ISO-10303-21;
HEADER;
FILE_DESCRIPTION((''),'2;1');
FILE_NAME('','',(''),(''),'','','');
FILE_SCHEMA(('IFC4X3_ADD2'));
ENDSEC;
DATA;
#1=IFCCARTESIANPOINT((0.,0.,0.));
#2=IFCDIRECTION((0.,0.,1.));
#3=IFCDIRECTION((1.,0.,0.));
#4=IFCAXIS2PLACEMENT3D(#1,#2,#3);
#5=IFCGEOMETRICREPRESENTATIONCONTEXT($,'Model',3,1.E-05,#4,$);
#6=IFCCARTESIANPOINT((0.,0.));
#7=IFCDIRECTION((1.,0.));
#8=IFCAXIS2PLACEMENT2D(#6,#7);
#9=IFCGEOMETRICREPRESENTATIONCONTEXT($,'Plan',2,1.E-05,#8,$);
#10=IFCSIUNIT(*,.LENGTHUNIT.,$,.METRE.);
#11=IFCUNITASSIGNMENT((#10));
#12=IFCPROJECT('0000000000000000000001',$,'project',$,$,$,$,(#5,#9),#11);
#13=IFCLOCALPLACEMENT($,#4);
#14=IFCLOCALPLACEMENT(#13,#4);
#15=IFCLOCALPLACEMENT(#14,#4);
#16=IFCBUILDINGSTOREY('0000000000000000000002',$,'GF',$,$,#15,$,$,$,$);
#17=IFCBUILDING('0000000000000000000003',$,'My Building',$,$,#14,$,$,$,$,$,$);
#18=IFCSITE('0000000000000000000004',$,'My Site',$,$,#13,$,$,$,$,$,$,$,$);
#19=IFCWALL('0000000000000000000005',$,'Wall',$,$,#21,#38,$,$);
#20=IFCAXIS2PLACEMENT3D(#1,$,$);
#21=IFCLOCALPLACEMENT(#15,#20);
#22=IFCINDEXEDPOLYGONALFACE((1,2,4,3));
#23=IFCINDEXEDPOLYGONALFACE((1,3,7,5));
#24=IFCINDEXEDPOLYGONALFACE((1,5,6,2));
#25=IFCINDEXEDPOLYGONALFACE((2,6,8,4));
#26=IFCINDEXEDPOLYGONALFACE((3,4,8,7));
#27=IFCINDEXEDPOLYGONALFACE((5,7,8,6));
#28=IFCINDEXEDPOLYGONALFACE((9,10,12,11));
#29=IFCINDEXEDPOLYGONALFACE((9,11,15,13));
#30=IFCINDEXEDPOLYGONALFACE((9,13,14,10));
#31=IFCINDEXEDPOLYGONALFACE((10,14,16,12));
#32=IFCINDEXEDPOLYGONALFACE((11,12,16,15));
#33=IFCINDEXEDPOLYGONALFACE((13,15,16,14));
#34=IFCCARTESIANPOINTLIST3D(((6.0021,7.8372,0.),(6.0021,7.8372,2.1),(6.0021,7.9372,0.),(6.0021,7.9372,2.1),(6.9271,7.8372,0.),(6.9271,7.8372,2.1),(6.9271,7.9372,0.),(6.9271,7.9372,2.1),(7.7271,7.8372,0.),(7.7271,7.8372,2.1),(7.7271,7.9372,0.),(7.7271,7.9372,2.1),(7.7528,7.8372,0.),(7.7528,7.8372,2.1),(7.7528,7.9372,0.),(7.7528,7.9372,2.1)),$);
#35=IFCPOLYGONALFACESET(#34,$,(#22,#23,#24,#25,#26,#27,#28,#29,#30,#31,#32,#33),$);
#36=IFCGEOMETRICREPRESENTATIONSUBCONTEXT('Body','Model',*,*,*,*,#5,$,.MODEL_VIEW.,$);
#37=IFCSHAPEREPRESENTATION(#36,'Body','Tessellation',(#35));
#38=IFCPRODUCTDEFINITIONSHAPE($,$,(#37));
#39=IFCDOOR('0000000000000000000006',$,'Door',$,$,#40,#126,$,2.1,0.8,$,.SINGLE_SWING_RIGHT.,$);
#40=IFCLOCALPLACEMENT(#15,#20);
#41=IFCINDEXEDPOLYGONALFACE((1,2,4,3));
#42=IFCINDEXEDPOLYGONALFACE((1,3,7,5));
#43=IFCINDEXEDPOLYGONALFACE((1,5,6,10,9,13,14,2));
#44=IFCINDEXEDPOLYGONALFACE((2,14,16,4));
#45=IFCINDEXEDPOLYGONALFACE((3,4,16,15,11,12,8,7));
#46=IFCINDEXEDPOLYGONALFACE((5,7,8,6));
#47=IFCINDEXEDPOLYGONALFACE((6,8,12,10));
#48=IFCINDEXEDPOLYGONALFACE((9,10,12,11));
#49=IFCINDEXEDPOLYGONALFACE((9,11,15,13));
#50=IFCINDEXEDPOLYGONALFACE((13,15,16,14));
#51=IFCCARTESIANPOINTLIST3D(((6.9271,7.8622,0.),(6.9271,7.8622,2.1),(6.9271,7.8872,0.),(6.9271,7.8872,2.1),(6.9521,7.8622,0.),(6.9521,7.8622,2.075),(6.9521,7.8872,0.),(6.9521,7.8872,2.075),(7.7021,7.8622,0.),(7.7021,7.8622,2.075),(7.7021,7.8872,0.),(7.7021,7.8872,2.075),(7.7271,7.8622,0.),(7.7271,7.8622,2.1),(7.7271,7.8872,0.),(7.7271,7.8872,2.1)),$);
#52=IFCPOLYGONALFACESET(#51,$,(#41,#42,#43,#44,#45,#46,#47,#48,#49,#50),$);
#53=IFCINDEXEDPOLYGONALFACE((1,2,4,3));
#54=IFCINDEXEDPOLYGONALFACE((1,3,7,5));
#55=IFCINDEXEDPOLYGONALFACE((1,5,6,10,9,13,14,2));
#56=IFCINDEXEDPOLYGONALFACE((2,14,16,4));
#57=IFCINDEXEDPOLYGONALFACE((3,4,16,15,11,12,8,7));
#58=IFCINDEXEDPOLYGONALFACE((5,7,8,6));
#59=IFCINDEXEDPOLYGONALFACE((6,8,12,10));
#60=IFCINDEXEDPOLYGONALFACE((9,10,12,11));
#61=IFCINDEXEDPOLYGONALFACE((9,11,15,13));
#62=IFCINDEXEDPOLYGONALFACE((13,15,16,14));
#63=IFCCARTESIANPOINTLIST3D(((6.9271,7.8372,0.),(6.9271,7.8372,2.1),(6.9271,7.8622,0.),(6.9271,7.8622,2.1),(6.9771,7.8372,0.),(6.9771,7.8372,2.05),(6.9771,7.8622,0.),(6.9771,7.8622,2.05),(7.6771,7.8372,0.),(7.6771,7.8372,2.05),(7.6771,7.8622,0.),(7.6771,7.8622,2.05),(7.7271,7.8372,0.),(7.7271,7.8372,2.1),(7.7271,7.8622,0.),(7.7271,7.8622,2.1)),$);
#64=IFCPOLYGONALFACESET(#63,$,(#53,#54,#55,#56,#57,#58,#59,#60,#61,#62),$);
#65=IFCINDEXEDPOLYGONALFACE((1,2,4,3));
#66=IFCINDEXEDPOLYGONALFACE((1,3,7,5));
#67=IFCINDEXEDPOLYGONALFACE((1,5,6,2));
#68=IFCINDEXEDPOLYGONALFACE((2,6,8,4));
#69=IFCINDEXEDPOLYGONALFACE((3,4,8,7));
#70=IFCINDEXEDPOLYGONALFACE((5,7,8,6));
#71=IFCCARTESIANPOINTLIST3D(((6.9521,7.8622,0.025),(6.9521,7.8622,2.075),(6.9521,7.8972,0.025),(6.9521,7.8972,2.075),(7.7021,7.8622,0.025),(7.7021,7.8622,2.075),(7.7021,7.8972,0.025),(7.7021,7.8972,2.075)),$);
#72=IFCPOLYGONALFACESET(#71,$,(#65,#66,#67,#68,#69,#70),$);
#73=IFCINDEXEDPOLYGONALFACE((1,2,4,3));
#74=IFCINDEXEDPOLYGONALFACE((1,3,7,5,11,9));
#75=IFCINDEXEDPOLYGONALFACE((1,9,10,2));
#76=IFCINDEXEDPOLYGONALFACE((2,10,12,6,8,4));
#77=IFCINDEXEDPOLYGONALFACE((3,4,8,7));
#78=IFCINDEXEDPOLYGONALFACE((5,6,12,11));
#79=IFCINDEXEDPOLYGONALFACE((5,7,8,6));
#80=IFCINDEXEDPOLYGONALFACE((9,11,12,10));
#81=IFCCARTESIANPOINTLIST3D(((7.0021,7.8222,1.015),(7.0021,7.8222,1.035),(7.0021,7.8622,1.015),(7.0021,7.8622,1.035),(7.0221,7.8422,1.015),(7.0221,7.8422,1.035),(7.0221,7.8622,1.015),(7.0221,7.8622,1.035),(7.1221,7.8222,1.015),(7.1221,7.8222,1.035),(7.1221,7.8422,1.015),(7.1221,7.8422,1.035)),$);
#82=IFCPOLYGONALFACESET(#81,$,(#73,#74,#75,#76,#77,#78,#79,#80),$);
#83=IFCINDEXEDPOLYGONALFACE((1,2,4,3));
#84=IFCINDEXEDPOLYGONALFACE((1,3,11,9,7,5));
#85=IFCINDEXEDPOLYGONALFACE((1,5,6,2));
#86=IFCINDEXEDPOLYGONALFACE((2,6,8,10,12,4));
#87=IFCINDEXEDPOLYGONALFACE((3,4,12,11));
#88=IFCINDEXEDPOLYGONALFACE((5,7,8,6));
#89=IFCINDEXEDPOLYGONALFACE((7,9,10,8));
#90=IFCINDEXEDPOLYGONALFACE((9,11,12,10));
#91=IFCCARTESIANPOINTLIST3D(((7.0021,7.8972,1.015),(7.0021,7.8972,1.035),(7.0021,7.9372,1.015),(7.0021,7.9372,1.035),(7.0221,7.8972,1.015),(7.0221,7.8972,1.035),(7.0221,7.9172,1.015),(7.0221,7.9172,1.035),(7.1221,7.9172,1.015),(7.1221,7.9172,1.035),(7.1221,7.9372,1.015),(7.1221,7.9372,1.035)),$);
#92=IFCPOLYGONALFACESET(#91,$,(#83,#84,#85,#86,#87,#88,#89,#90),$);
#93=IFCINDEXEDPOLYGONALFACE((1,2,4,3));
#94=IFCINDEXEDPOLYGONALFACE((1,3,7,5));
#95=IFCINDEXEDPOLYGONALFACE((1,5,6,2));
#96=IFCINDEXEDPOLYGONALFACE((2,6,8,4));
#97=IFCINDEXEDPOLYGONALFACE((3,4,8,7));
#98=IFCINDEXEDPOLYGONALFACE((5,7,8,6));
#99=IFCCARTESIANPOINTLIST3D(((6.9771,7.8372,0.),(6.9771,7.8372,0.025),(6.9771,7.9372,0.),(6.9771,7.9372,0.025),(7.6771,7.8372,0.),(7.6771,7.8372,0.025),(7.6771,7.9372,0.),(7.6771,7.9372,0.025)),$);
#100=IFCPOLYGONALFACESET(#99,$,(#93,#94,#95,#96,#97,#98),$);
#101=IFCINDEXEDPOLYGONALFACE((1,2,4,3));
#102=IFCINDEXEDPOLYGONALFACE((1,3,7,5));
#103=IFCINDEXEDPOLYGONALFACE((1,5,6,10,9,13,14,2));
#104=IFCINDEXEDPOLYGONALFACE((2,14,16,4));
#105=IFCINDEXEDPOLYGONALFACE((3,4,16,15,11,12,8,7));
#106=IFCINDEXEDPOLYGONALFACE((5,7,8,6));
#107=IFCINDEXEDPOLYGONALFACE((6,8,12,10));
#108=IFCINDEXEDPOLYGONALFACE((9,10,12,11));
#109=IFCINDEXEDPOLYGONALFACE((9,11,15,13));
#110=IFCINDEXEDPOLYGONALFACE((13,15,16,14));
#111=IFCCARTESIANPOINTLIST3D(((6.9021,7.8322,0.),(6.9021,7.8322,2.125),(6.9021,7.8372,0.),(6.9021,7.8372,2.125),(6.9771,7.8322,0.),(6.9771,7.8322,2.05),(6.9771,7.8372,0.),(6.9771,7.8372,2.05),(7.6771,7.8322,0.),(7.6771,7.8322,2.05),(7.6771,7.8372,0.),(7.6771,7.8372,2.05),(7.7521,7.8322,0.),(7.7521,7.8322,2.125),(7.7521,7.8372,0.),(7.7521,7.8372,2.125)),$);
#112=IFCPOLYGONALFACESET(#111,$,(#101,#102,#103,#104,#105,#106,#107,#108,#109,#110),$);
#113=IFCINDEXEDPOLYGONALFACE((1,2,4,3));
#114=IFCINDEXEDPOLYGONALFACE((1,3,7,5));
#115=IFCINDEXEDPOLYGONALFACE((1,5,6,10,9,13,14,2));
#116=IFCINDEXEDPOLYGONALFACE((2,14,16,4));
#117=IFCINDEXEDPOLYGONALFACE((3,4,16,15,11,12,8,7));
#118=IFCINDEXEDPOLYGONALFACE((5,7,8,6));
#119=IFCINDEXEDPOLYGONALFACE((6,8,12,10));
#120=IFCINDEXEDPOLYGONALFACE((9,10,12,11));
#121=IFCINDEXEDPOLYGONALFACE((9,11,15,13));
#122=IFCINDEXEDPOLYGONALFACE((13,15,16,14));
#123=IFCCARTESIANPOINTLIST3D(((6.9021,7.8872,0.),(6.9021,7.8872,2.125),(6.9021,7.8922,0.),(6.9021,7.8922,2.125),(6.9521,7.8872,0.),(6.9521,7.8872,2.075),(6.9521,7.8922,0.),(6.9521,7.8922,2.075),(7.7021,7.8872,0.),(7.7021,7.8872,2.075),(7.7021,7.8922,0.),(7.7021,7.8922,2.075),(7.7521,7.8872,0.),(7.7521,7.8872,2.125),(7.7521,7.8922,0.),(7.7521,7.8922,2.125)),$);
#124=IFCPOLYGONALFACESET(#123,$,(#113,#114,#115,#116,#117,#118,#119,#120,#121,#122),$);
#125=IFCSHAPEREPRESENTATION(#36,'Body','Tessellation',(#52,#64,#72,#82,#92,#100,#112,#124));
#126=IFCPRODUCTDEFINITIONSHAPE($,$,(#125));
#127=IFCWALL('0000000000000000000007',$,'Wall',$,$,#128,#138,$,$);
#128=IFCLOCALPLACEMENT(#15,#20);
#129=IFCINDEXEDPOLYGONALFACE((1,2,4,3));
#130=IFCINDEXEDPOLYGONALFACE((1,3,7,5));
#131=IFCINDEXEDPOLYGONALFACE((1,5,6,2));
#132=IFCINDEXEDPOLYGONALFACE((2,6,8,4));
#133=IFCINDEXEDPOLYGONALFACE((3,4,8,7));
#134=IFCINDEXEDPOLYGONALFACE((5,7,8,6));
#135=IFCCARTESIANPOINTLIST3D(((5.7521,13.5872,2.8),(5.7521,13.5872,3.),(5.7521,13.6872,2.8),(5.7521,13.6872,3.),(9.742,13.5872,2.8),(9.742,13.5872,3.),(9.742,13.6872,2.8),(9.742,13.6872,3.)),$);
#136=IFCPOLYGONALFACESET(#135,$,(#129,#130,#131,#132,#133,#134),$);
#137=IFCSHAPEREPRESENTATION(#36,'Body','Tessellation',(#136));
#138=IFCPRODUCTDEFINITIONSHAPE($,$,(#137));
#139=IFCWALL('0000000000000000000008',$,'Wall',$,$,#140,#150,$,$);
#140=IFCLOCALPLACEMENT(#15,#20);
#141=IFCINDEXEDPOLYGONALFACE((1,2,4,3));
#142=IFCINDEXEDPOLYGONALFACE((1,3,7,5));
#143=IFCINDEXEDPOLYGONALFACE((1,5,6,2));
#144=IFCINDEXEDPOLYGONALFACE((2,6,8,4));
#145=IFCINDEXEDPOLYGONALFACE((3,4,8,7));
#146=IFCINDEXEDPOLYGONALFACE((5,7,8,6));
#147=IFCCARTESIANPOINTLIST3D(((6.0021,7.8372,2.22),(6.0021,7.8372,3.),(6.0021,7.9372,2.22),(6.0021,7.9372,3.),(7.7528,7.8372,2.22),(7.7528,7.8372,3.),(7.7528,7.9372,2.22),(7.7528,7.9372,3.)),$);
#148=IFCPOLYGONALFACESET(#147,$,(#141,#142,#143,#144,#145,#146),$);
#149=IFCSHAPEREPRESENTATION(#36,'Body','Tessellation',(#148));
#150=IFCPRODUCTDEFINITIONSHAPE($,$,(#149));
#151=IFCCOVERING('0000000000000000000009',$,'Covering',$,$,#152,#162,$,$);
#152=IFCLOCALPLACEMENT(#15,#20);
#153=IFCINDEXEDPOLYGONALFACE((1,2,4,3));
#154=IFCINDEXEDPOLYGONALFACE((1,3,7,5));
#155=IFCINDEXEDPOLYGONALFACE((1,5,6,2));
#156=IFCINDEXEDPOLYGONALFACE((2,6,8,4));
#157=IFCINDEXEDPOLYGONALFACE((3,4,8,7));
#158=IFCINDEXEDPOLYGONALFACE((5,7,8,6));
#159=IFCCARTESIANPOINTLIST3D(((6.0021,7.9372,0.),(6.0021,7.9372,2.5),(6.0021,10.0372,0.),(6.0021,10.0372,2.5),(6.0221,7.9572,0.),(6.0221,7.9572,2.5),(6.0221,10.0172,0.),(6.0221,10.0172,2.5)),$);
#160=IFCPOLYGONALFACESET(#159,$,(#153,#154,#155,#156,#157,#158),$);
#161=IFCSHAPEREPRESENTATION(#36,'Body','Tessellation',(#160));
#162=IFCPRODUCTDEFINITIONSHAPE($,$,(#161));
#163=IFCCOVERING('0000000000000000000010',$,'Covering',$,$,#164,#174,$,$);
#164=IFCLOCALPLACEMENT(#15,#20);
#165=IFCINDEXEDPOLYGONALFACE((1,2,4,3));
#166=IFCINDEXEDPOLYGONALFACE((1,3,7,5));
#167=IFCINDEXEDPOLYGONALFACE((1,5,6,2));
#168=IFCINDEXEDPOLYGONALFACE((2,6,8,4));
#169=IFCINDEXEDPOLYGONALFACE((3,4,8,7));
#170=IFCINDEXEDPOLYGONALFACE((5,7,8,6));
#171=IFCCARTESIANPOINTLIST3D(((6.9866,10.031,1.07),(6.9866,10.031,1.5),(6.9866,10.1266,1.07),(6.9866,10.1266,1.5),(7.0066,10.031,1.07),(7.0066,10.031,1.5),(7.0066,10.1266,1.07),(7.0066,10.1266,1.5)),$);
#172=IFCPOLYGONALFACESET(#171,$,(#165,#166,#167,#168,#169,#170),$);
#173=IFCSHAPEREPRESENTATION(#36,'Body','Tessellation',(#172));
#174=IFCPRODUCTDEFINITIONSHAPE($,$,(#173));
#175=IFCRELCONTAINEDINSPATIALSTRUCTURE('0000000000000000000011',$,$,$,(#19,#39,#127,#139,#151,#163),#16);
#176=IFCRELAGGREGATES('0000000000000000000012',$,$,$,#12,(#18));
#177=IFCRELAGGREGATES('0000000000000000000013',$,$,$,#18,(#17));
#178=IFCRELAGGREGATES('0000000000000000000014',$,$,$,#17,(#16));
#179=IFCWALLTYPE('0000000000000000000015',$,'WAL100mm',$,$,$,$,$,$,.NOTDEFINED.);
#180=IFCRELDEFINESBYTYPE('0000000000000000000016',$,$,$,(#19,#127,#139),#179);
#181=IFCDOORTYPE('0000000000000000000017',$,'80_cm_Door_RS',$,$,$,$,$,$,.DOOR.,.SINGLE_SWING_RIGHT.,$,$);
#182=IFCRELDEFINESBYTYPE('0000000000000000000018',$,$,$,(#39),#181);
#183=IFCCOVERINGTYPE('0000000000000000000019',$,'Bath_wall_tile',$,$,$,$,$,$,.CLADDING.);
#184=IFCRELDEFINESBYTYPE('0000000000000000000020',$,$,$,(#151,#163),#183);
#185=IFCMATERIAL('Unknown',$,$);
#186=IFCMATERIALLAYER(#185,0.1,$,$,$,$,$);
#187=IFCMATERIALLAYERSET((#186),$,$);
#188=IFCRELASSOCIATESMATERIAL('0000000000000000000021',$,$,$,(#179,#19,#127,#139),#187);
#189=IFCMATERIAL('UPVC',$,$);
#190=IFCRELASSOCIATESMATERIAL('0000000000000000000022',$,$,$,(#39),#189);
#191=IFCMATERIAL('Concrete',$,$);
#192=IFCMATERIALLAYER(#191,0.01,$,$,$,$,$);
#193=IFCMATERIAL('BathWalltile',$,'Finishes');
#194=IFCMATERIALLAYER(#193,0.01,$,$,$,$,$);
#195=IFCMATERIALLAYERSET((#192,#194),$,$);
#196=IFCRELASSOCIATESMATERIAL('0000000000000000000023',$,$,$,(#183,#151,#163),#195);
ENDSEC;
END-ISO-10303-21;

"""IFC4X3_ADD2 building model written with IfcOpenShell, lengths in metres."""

from ifc_helpers import new_model, entity, si_unit, frame, origin_with_axes, origin_2d_with_axis, place, context, subcontext, project, spatial, line, indexed_curve, outline, extrude, shape, source, transform, mapped, material, layer, layer_set, layer_usage, type_object, type_shapes, element, fill, save


model = new_model("IFC4X3_ADD2")

# Units and contexts
model_context = context("Model", 3, precision=1e-05, world=origin_with_axes())
plan_context = context("Plan", 2, precision=1e-05, world=origin_2d_with_axis())
body_context_1 = subcontext(model_context, "Body", "Model", "MODEL_VIEW")
body_context_2 = subcontext(plan_context, "Body", "Plan", "PLAN_VIEW")
ifc_project = project(units=[si_unit("LENGTHUNIT", "METRE")], contexts=[model_context, plan_context])

# Site, building, storey
site_placement = place(None, origin_with_axes())
site = spatial("IfcSite", under=ifc_project, at=site_placement, Name="My Site")
building_placement = place(site_placement, origin_with_axes())
building = spatial("IfcBuilding", under=site, at=building_placement, Name="My Building")
storey_placement = place(building_placement, origin_with_axes())
storey = spatial("IfcBuildingStorey", under=building, at=storey_placement, Name="GF")

# Shared definitions
ifc_material_1 = material(Name="UPVC")

# Shared definitions
ifc_material_2 = material(Name="Unknown")
ifc_layer_1 = layer(ifc_material_2, 0.1)
ifc_layer_set_1 = layer_set([ifc_layer_1])
wall_type_1 = type_object("IfcWallType", Name="WAL100mm", PredefinedType="NOTDEFINED", material=ifc_layer_set_1)

# Wall, opening, door
ifc_layer_usage_1 = layer_usage(ifc_layer_set_1, "AXIS2", "POSITIVE", 0.0)
wall_1_placement = place(storey_placement, frame((6.0021, 7.8372, 0.0), z_axis=(0.0, 0.0, 1.0), x_axis=(1.0, 0.0, 0.0)))
wall_1 = element("IfcWall", 1, at=wall_1_placement, inside=storey, type_object=wall_type_1, material=ifc_layer_usage_1, Name="Wall", context=body_context_1, shape_type="SweptSolid", body=[
    extrude(outline(indexed_curve([(0.0, 0.0), (0.0, 0.1), (1.7507, 0.1), (1.7507, 0.0)], segments=[line(1, 2, 3, 4, 1)])), origin_with_axes(), (0.0, 0.0, 1.0), 2.1),
])
shared_shape_1 = source(origin_with_axes(), body_context_1, "Body", "SweptSolid", [
    extrude(outline(indexed_curve([(0.0, 0.0), (0.8, 0.0), (0.8, 2.1), (0.0, 2.1)], segments=[line(1, 2, 3, 4, 1)])), frame((0.0, -0.6, 0.0), z_axis=(0.0, -1.0, 0.0), x_axis=(1.0, 0.0, 0.0)), (0.0, 0.0, -1.0), 1.2),
])
opening_1_placement = place(wall_1_placement, frame((0.925, 0.0, 0.0), z_axis=(0.0, 0.0, 1.0), x_axis=(1.0, -0.000003, 0.0)))
opening_1 = element("IfcOpeningElement", 2, at=opening_1_placement, cuts=wall_1, PredefinedType="OPENING", context=body_context_1, shape_type="MappedRepresentation", body=[
    mapped(shared_shape_1, transform((0.0, 0.0, 0.0), x_axis=(1.0, 0.0, 0.0), y_axis=(0.0, 1.0, 0.0), z_axis=(0.0, 0.0, 1.0), scale=1.0)),
])
door_type_1 = type_object("IfcDoorType", Name="80_cm_Door_RS", OperationType="SINGLE_SWING_RIGHT", PredefinedType="DOOR")
shared_shape_2 = source(origin_with_axes(), body_context_1, "Body", "SweptSolid", [
    extrude(outline(indexed_curve([(0.0, 0.0), (0.0, 2.1), (0.8, 2.1), (0.8, 0.0), (0.775, 0.0), (0.775, 2.075), (0.025, 2.075), (0.025, 0.0)], segments=[line(1, 2, 3, 4, 5, 6, 7, 8, 1)])), frame((0.0, 0.025, 0.0), z_axis=(0.0, -1.0, 0.0), x_axis=(1.0, 0.0, 0.0)), (0.0, 0.0, -1.0), 0.025),
    extrude(outline(indexed_curve([(0.0, 0.0), (0.0, 2.1), (0.8, 2.1), (0.8, 0.0), (0.75, 0.0), (0.75, 2.05), (0.05, 2.05), (0.05, 0.0)], segments=[line(1, 2, 3, 4, 5, 6, 7, 8, 1)])), frame((0.0, 0.0, 0.0), z_axis=(0.0, -1.0, 0.0), x_axis=(1.0, 0.0, 0.0)), (0.0, 0.0, -1.0), 0.025),
    extrude(outline(indexed_curve([(0.0, 0.0), (0.75, 0.0), (0.75, 0.035), (0.0, 0.035)], segments=[line(1, 2, 3, 4, 1)])), frame((0.025, 0.025, 0.025), z_axis=(0.0, 0.0, 1.0), x_axis=(1.0, 0.0, 0.0)), (0.0, 0.0, 1.0), 2.05),
    extrude(outline(indexed_curve([(0.0, 0.0), (0.0, -0.04), (0.12, -0.04), (0.12, -0.02), (0.02, -0.02), (0.02, 0.0)], segments=[line(1, 2, 3, 4, 5, 6, 1)])), frame((0.075, 0.025, 1.015), z_axis=(0.0, 0.0, 1.0), x_axis=(1.0, 0.0, 0.0)), (0.0, 0.0, 1.0), 0.02),
    extrude(outline(indexed_curve([(0.0, 0.0), (0.0, 0.04), (0.12, 0.04), (0.12, 0.02), (0.02, 0.02), (0.02, 0.0)], segments=[line(1, 2, 3, 4, 5, 6, 1)])), frame((0.075, 0.06, 1.015), z_axis=(0.0, 0.0, 1.0), x_axis=(1.0, 0.0, 0.0)), (0.0, 0.0, 1.0), 0.02),
    extrude(outline(indexed_curve([(0.0, 0.0), (0.7, 0.0), (0.7, 0.1), (0.0, 0.1)], segments=[line(1, 2, 3, 4, 1)])), frame((0.05, 0.0, 0.0), z_axis=(0.0, 0.0, 1.0), x_axis=(1.0, 0.0, 0.0)), (0.0, 0.0, 1.0), 0.025),
    extrude(outline(indexed_curve([(0.0, 0.0), (0.0, 2.125), (0.85, 2.125), (0.85, 0.0), (0.775, 0.0), (0.775, 2.05), (0.075, 2.05), (0.075, 0.0)], segments=[line(1, 2, 3, 4, 5, 6, 7, 8, 1)])), frame((-0.025, -0.005, 0.0), z_axis=(0.0, -1.0, 0.0), x_axis=(1.0, 0.0, 0.0)), (0.0, 0.0, -1.0), 0.005),
    extrude(outline(indexed_curve([(0.0, 0.0), (0.0, 2.125), (0.85, 2.125), (0.85, 0.0), (0.8, 0.0), (0.8, 2.075), (0.05, 2.075), (0.05, 0.0)], segments=[line(1, 2, 3, 4, 5, 6, 7, 8, 1)])), frame((-0.025, 0.05, 0.0), z_axis=(0.0, -1.0, 0.0), x_axis=(1.0, 0.0, 0.0)), (0.0, 0.0, -1.0), 0.005),
])
shared_shape_3 = source(origin_with_axes(), body_context_2, "Body", "Curve2D", [
    entity("IfcIndexedPolyCurve", entity("IfcCartesianPointList2D", [[0.0, 0.0], [0.0, 0.05], [0.025, 0.05], [0.025, 0.025], [0.05, 0.025], [0.05, 0.0]]), [entity("IfcLineIndex", [1, 2, 3, 4, 5, 6, 1])]),
    entity("IfcIndexedPolyCurve", entity("IfcCartesianPointList2D", [[0.8, 0.0], [0.8, 0.05], [0.775, 0.05], [0.775, 0.025], [0.75, 0.025], [0.75, 0.0]]), [entity("IfcLineIndex", [1, 2, 3, 4, 5, 6, 1])]),
    entity("IfcTrimmedCurve", entity("IfcEllipse", entity("IfcAxis2Placement2D", entity("IfcCartesianPoint", [0.74, 0.05]), entity("IfcDirection", [1.0, 0.0])), 0.715, 0.75), [entity("IfcCartesianPoint", [0.74, 0.8])], [entity("IfcCartesianPoint", [0.025, 0.05])], True, "CARTESIAN"),
    entity("IfcIndexedPolyCurve", entity("IfcCartesianPointList2D", [[0.775, 0.05], [0.74, 0.05], [0.74, 0.8], [0.775, 0.8]]), [entity("IfcLineIndex", [1, 2, 3, 4, 1])]),
])
type_shapes(door_type_1, [shared_shape_2, shared_shape_3])
door_1_placement = place(opening_1_placement, frame((0.0, 0.0, 0.0), z_axis=(0.0, 0.0, 1.0), x_axis=(1.0, 0.0, 0.0)))
door_1 = element("IfcDoor", 3, at=door_1_placement, inside=storey, type_object=door_type_1, material=ifc_material_1, Name="Door", OperationType="SINGLE_SWING_RIGHT", OverallHeight=2.1, OverallWidth=0.8, shapes=[
    shape(body_context_1, "Body", "MappedRepresentation", [mapped(shared_shape_2, transform((0.0, 0.0, 0.0), x_axis=(1.0, 0.0, 0.0), y_axis=(0.0, 1.0, 0.0), z_axis=(0.0, 0.0, 1.0), scale=1.0))]),
    shape(body_context_2, "Body", "MappedRepresentation", [mapped(shared_shape_3, transform((0.0, 0.0, 0.0), x_axis=(1.0, 0.0, 0.0), y_axis=(0.0, 1.0, 0.0), z_axis=(0.0, 0.0, 1.0), scale=1.0))]),
])
fill(opening_1, door_1)

# Walls
ifc_layer_usage_2 = layer_usage(ifc_layer_set_1, "AXIS2", "POSITIVE", 0.0)
wall_2_placement = place(storey_placement, frame((5.7521, 13.5872, 2.8), z_axis=(0.0, 0.0, 1.0), x_axis=(1.0, 0.0, 0.0)))
element("IfcWall", 4, at=wall_2_placement, inside=storey, type_object=wall_type_1, material=ifc_layer_usage_2, Name="Wall", context=body_context_1, shape_type="SweptSolid", body=[
    extrude(outline(indexed_curve([(0.0, 0.0), (0.0, 0.1), (3.9899, 0.1), (3.9899, 0.0)], segments=[line(1, 2, 3, 4, 1)])), origin_with_axes(), (0.0, 0.0, 1.0), 0.2),
])
ifc_layer_usage_3 = layer_usage(ifc_layer_set_1, "AXIS2", "POSITIVE", 0.0)
wall_3_placement = place(storey_placement, frame((6.0021, 7.8372, 2.22), z_axis=(0.0, 0.0, 1.0), x_axis=(1.0, 0.0, 0.0)))
element("IfcWall", 5, at=wall_3_placement, inside=storey, type_object=wall_type_1, material=ifc_layer_usage_3, Name="Wall", context=body_context_1, shape_type="SweptSolid", body=[
    extrude(outline(indexed_curve([(0.0, 0.0), (0.0, 0.1), (1.7507, 0.1), (1.7507, 0.0)], segments=[line(1, 2, 3, 4, 1)])), origin_with_axes(), (0.0, 0.0, 1.0), 0.78),
])

# Coverings
ifc_material_3 = material(Name="Concrete")
ifc_layer_2 = layer(ifc_material_3, 0.01)
ifc_material_4 = material(Name="BathWalltile", Category="Finishes")
ifc_layer_3 = layer(ifc_material_4, 0.01)
ifc_layer_set_2 = layer_set([ifc_layer_2, ifc_layer_3])
ifc_layer_usage_4 = layer_usage(ifc_layer_set_2, "AXIS2", "POSITIVE", 0.0)
covering_type = type_object("IfcCoveringType", Name="Bath_wall_tile", PredefinedType="CLADDING", material=ifc_layer_set_2)
covering_1_placement = place(storey_placement, frame((6.0021, 10.0372, 0.0), z_axis=(0.0, 0.0, 1.0), x_axis=(0.0, -1.0, 0.0)))
element("IfcCovering", 6, at=covering_1_placement, inside=storey, type_object=covering_type, material=ifc_layer_usage_4, Name="Covering", context=body_context_1, shape_type="SweptSolid", body=[
    extrude(outline(indexed_curve([(0.0, 0.0), (0.02, 0.02), (2.08, 0.02), (2.1, 0.0)], segments=[line(1, 2, 3, 4, 1)])), origin_with_axes(), (0.0, 0.0, 1.0), 2.5),
])
ifc_layer_usage_5 = layer_usage(ifc_layer_set_2, "AXIS2", "NEGATIVE", 0.0)
covering_2_placement = place(storey_placement, frame((6.9866, 10.031, 1.07), z_axis=(0.0, 0.0, 1.0), x_axis=(0.0, 1.0, 0.0)))
element("IfcCovering", 7, at=covering_2_placement, inside=storey, type_object=covering_type, material=ifc_layer_usage_5, Name="Covering", context=body_context_1, shape_type="SweptSolid", body=[
    extrude(outline(indexed_curve([(0.0, -0.02), (0.0, 0.0), (0.0956, 0.0), (0.0956, -0.02)], segments=[line(1, 2, 3, 4, 1)])), origin_with_axes(), (0.0, 0.0, 1.0), 0.43),
])

save(model, "model.ifc")
